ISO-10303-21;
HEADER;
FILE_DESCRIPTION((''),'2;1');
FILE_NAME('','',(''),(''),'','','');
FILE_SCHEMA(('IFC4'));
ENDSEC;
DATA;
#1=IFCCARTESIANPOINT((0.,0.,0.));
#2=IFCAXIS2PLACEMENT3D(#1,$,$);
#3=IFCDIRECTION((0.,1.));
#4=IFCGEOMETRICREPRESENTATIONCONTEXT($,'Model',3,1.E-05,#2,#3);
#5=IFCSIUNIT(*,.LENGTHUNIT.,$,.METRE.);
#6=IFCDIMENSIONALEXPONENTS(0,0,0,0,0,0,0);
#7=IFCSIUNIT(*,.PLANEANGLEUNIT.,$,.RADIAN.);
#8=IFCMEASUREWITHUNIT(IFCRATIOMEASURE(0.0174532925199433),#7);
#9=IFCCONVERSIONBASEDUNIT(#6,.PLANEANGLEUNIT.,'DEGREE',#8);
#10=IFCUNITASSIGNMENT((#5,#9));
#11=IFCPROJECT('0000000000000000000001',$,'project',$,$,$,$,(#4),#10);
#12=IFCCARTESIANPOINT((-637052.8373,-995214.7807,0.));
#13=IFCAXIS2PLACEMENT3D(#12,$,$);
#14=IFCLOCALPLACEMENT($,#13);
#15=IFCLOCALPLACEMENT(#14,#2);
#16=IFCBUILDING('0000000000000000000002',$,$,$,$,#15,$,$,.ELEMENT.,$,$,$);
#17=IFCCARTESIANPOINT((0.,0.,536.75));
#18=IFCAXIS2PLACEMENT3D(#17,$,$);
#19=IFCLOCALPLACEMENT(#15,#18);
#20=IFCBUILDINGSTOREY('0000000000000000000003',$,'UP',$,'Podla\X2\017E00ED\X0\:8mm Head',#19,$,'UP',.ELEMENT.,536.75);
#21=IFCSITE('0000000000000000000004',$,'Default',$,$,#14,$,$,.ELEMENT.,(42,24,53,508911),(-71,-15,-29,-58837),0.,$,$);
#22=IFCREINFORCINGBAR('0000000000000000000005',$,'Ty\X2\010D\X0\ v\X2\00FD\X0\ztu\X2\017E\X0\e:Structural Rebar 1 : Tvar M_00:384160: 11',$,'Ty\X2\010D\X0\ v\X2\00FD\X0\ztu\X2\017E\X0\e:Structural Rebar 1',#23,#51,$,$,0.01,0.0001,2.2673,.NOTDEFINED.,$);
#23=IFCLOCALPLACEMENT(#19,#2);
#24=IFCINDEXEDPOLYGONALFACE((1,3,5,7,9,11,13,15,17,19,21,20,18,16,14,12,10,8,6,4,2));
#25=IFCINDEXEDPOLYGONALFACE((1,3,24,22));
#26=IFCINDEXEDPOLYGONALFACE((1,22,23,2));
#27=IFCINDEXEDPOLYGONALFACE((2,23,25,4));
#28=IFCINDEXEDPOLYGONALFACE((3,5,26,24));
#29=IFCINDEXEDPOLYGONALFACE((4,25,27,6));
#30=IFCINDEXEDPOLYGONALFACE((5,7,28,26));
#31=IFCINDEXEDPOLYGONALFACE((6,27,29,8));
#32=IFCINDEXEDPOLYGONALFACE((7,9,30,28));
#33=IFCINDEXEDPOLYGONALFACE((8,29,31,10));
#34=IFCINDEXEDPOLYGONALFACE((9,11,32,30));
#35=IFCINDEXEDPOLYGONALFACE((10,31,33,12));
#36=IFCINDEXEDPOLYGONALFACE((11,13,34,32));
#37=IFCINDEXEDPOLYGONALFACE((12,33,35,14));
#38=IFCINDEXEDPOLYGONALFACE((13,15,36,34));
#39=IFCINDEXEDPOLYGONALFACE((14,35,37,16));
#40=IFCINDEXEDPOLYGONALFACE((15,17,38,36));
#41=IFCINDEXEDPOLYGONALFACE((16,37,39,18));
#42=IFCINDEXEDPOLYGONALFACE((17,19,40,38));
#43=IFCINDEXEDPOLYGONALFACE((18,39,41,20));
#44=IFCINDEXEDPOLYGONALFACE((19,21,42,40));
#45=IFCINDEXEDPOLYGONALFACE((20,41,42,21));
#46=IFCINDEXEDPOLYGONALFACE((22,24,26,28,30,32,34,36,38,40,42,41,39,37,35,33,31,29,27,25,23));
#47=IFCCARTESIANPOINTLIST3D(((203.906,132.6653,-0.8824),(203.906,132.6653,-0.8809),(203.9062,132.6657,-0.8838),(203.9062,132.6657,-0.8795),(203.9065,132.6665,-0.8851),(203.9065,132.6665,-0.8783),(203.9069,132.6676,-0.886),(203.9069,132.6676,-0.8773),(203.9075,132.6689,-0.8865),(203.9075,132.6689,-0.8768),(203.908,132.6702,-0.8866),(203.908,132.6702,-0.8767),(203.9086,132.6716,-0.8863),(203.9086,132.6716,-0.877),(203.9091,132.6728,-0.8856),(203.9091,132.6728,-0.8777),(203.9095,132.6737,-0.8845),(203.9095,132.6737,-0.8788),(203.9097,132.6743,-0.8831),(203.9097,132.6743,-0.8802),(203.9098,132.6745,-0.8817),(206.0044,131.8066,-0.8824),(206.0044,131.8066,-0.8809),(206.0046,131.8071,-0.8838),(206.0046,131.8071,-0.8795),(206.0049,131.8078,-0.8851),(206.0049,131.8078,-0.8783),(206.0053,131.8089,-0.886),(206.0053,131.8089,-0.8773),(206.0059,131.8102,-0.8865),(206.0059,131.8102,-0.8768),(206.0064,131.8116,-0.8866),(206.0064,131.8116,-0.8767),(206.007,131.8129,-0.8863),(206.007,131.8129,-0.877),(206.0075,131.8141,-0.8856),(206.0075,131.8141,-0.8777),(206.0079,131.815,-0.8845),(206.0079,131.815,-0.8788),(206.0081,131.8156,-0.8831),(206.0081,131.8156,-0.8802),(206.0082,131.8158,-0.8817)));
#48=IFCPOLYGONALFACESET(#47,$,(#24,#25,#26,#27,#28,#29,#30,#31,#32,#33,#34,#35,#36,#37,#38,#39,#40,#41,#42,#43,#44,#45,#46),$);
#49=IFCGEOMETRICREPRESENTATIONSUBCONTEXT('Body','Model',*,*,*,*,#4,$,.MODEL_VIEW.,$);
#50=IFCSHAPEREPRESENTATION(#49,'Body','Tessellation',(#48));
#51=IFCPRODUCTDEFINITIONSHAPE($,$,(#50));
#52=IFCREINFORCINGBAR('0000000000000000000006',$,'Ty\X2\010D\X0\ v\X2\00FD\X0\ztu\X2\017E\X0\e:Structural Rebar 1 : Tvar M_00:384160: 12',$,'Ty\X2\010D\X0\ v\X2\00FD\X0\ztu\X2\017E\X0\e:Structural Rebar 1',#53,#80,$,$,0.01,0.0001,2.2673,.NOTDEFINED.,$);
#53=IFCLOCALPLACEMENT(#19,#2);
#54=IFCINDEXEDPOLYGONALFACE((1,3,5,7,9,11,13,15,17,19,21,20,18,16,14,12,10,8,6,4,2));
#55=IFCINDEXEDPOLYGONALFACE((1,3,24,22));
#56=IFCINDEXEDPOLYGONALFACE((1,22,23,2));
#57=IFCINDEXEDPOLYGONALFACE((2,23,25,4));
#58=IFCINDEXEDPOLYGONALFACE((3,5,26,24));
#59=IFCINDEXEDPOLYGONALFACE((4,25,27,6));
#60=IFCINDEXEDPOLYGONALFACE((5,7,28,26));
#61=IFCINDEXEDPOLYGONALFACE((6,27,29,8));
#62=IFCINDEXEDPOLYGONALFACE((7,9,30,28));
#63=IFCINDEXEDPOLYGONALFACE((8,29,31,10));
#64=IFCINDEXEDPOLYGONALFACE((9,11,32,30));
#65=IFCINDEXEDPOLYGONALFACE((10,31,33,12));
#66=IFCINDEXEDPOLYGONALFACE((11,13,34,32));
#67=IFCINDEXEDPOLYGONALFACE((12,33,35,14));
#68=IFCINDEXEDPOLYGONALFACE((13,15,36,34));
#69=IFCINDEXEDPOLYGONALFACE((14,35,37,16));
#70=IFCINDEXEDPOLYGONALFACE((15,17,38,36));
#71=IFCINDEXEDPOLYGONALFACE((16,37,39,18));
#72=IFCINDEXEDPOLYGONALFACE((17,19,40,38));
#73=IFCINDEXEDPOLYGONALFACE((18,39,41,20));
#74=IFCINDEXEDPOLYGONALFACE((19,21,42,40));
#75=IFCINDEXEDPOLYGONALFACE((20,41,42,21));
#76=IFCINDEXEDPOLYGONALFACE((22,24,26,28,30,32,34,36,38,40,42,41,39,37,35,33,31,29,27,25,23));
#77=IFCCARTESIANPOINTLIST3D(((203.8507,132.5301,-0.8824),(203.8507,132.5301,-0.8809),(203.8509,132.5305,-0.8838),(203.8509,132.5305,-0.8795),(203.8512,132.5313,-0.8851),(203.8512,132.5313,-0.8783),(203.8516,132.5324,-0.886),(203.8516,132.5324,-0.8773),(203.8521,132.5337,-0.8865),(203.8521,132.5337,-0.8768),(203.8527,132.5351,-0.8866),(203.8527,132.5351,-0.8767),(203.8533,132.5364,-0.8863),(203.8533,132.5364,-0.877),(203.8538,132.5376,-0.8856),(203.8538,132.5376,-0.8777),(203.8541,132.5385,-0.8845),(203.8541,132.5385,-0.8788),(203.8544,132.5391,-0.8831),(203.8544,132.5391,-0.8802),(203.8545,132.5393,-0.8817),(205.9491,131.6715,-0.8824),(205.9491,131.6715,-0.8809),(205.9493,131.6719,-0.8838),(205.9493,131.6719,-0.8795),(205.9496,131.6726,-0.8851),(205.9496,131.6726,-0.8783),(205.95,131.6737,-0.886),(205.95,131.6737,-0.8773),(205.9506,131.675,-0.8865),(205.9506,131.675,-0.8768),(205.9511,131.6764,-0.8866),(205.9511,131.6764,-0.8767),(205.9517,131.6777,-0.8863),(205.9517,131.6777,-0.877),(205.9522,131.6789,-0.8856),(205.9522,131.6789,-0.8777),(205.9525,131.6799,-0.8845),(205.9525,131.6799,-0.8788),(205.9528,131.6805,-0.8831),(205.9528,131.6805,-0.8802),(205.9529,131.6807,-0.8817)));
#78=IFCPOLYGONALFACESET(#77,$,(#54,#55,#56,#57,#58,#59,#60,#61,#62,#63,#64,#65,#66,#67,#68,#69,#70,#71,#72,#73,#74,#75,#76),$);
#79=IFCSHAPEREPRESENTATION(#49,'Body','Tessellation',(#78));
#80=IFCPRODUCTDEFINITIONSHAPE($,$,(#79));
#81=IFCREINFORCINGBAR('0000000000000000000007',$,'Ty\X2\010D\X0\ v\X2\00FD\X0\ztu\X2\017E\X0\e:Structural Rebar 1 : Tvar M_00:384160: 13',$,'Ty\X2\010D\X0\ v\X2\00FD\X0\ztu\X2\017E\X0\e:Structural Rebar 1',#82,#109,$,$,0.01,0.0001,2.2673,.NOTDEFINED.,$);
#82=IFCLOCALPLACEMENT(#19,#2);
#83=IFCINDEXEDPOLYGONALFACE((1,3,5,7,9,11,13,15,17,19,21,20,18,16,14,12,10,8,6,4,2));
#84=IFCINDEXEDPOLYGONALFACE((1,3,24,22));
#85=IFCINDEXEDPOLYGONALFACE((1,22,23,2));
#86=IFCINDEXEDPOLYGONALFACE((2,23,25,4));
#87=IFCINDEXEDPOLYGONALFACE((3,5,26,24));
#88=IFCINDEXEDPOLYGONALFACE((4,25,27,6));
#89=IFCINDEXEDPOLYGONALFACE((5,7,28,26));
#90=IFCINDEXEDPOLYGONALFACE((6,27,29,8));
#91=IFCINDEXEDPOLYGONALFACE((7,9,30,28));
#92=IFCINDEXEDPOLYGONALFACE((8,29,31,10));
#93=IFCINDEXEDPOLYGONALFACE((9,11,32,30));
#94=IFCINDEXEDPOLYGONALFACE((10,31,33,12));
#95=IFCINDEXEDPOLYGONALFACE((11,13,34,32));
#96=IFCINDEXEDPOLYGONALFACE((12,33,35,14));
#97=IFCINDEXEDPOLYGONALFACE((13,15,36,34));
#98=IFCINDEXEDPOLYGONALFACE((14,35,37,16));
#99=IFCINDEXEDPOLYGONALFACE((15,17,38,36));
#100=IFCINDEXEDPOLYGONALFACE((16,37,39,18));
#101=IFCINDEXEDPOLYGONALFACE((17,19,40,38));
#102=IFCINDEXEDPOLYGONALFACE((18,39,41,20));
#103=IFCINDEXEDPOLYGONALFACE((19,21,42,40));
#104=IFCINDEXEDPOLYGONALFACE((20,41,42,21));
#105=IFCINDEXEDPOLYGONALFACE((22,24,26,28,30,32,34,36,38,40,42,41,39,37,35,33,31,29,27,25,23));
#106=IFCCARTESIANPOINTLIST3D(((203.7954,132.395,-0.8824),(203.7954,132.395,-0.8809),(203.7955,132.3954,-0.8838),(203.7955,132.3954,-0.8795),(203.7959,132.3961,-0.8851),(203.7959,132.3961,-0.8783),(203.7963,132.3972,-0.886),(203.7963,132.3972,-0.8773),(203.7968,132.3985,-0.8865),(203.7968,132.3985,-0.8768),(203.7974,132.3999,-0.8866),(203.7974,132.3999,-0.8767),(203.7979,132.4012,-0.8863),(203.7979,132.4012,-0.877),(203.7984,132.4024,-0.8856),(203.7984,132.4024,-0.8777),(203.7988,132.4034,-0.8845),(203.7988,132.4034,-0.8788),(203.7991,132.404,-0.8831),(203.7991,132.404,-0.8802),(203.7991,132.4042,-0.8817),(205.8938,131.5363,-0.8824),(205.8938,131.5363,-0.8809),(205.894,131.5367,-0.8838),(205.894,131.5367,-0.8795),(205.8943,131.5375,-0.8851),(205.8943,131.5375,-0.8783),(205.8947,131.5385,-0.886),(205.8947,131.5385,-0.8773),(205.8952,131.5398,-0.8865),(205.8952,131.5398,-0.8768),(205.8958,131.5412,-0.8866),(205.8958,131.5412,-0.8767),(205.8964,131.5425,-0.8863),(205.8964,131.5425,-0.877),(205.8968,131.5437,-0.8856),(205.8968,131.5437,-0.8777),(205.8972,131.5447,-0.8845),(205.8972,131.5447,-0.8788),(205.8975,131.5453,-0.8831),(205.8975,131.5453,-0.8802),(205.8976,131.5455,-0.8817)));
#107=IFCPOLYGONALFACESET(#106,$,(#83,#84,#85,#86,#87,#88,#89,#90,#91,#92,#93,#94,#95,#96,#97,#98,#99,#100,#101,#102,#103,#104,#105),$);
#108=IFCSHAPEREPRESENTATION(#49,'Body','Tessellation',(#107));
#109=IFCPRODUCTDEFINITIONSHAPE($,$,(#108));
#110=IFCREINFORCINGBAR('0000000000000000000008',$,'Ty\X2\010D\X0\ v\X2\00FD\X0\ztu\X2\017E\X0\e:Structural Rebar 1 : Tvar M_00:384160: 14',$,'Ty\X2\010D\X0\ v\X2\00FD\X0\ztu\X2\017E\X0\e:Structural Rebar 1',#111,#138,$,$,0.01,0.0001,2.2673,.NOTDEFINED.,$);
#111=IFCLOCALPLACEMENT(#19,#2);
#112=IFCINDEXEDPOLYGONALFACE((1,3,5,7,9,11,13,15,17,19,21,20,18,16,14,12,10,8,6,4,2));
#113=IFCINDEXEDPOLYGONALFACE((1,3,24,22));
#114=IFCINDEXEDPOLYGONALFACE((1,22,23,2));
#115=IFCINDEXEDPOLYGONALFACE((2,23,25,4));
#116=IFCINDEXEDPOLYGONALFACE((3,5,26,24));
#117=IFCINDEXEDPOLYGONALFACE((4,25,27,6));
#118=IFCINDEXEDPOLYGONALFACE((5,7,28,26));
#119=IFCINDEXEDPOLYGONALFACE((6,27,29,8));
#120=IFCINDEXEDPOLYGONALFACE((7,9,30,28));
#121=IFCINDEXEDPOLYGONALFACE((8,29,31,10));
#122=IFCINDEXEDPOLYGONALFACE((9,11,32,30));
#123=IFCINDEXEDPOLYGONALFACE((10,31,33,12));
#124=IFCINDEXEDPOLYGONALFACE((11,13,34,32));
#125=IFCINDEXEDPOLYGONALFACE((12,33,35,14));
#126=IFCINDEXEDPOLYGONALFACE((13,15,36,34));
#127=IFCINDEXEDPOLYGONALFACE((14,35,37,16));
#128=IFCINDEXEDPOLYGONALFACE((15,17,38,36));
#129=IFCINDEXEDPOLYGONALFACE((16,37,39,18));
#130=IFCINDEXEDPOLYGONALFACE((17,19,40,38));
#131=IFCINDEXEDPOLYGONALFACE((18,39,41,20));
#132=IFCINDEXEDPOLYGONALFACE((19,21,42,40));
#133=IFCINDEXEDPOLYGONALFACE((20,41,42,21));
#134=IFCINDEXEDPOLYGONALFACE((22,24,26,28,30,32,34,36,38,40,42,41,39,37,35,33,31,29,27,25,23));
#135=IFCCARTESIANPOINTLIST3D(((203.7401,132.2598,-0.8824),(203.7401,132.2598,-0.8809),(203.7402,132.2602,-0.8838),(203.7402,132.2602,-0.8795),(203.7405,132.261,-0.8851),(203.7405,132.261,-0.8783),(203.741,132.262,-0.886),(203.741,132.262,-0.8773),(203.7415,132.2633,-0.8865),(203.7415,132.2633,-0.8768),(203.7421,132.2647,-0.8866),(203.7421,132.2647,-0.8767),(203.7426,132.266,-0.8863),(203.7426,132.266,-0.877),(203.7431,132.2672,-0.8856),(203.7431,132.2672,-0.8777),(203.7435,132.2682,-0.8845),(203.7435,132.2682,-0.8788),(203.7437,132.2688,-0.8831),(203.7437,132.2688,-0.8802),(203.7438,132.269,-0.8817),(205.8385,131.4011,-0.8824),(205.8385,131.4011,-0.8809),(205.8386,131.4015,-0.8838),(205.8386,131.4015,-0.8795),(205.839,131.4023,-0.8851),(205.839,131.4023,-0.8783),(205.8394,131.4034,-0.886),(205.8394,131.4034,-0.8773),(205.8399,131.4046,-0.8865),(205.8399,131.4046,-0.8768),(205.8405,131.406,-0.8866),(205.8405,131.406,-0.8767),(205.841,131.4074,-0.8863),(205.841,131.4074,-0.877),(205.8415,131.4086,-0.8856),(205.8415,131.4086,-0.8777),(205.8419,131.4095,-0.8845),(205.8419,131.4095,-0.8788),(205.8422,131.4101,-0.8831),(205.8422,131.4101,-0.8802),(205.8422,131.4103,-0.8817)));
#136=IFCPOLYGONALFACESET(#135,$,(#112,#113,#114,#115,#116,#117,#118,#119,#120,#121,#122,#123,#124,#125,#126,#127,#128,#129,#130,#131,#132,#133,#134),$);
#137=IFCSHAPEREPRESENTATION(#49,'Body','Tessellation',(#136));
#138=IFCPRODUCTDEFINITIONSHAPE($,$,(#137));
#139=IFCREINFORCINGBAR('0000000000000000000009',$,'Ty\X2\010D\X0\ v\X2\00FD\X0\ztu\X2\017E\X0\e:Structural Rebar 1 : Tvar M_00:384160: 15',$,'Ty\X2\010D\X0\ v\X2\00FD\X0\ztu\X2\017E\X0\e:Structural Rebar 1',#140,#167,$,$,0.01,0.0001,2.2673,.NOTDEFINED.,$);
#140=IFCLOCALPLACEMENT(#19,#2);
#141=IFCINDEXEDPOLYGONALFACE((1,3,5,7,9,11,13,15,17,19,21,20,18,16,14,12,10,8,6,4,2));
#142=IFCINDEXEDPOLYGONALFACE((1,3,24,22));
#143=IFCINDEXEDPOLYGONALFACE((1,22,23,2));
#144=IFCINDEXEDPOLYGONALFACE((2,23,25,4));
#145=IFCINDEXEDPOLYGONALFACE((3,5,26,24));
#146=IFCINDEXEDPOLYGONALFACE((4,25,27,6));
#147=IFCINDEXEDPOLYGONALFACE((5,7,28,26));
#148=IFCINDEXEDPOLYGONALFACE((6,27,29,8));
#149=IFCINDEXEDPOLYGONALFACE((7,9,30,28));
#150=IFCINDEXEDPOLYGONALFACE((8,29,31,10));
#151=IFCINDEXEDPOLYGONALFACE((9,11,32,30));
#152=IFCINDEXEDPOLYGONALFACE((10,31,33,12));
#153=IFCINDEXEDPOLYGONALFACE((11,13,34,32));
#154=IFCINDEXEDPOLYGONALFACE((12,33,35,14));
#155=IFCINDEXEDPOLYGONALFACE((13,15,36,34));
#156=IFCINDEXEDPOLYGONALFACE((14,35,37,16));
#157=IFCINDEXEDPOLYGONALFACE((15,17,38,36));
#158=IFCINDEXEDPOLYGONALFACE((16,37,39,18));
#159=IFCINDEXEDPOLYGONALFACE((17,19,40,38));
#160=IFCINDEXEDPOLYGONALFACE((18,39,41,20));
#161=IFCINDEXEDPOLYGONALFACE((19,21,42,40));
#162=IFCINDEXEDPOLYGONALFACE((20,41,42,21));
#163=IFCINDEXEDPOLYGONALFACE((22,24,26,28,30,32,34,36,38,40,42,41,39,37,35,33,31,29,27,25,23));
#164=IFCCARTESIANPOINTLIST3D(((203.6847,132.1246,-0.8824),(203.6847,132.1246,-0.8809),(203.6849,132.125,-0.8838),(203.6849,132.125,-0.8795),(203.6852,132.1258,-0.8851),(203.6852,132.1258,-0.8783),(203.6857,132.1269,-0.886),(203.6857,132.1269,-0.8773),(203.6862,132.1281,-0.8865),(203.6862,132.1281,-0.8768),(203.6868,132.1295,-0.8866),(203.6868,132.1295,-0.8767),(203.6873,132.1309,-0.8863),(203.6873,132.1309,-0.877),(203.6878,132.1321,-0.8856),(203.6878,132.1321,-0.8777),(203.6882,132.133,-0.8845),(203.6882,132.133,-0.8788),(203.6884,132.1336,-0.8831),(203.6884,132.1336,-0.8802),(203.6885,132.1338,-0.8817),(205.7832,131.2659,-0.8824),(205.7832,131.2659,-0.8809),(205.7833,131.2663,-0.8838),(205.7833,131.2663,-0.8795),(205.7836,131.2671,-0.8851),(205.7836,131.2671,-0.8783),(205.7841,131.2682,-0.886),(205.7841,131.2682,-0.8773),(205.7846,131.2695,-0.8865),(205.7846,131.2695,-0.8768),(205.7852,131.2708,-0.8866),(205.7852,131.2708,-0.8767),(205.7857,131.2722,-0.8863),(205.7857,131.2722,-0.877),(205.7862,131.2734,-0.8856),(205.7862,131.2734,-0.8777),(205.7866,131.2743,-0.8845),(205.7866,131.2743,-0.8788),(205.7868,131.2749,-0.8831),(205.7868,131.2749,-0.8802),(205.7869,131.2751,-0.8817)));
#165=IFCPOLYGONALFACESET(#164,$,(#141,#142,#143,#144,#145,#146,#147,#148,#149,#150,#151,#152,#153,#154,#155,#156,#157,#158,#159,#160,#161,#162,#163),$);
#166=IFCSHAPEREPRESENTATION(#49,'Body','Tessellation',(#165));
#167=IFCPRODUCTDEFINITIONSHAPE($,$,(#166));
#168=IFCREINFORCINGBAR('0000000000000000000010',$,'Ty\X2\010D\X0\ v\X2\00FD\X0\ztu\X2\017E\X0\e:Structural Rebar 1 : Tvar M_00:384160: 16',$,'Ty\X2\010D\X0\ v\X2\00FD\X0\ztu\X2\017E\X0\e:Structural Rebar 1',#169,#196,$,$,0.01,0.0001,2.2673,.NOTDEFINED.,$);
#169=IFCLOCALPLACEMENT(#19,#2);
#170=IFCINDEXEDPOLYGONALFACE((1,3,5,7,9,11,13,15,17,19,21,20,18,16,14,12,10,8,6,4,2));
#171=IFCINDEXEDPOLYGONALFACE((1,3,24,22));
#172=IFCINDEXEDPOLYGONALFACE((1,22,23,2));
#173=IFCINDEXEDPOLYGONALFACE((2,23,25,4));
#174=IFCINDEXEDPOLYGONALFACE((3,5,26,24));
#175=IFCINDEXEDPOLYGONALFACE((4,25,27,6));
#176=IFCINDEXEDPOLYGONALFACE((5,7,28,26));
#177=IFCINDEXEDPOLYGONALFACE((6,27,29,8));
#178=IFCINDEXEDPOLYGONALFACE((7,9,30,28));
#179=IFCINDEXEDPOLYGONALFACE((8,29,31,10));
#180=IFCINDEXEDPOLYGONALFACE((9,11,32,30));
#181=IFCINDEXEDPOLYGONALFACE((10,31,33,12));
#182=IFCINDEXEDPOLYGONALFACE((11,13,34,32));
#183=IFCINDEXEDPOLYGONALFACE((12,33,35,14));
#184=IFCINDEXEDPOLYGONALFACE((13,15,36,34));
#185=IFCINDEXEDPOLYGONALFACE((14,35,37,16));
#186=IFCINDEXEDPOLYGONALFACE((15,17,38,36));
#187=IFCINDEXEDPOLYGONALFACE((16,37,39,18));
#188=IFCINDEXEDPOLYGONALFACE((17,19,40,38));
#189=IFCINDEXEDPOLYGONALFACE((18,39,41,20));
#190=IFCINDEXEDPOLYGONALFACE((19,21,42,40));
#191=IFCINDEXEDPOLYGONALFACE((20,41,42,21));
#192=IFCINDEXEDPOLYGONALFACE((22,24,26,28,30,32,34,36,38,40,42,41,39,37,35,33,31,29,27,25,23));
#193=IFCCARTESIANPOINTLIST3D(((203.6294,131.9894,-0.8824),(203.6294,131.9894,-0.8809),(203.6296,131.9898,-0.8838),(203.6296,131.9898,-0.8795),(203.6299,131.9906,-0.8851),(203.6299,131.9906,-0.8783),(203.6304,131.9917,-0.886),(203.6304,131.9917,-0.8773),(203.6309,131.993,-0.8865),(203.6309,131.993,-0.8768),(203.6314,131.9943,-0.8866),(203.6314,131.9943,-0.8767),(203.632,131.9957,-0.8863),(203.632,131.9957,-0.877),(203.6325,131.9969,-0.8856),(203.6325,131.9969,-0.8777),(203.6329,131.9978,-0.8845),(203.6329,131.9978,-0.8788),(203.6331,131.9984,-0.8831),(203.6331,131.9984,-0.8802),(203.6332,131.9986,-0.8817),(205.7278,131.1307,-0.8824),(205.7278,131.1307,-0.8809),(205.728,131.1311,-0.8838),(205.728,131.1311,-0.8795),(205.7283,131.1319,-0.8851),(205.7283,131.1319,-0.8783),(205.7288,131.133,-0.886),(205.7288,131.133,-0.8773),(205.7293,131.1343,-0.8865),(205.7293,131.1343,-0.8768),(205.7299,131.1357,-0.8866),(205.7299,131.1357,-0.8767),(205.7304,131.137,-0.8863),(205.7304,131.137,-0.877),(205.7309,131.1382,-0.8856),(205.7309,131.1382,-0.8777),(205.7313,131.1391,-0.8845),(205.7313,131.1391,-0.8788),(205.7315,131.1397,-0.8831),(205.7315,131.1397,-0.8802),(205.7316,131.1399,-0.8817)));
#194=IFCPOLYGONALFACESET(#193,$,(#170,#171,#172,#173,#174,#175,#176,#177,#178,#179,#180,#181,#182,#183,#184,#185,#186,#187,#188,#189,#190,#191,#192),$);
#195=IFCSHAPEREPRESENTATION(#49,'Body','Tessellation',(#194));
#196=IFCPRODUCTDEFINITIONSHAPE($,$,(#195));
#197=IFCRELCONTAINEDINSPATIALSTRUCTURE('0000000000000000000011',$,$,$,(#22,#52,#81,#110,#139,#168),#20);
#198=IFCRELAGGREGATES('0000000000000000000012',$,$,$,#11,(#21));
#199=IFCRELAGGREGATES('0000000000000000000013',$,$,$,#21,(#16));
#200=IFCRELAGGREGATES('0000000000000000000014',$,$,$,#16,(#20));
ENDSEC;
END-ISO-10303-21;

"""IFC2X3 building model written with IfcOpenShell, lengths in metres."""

from ifc_helpers import new_model, entity, si_unit, converted_unit, direction, frame, origin, place, context, subcontext, project, spatial, element, save


model = new_model("IFC2X3")

# Units and contexts
model_context = context("Model", 3, precision=1e-05, world=origin(), true_north=direction((0.0, 1.0)))
body_context = subcontext(model_context, "Body", "Model", "MODEL_VIEW")
ifc_project = project(units=[si_unit("LENGTHUNIT", "METRE"), converted_unit("PLANEANGLEUNIT", "DEGREE", entity("IfcRatioMeasure", 0.0174532925199433), si_unit("PLANEANGLEUNIT", "RADIAN"), dimensions=[0, 0, 0, 0, 0, 0, 0])], contexts=[model_context])

# Site, building, storey
site_placement = place(None, frame((-637052.8373, -995214.7807, 0.0)))
site = spatial("IfcSite", under=ifc_project, at=site_placement, Name="Default", CompositionType="ELEMENT", RefLatitude=(42, 24, 53, 508911), RefLongitude=(-71, -15, -29, -58837), RefElevation=0.0)
building_placement = place(site_placement, origin())
building = spatial("IfcBuilding", under=site, at=building_placement, CompositionType="ELEMENT")
storey_placement = place(building_placement, frame((0.0, 0.0, 536.75)))
storey = spatial("IfcBuildingStorey", under=building, at=storey_placement, Name="UP", ObjectType="Podlaží:8mm Head", LongName="UP", CompositionType="ELEMENT", Elevation=536.75)

# Reinforcing bars
reinforcing_bar_1_placement = place(storey_placement, origin())
element("IfcReinforcingBar", 1, at=reinforcing_bar_1_placement, inside=storey, Name="Tyč výztuže:Structural Rebar 1 : Tvar M_00:384160: 11", ObjectType="Tyč výztuže:Structural Rebar 1", BarLength=2.2673, BarRole="NOTDEFINED", CrossSectionArea=0.0001, NominalDiameter=0.01, context=body_context, shape_type="AdvancedSweptSolid", body=[
    entity("IfcSweptDiskSolid", entity("IfcCompositeCurve", [entity("IfcCompositeCurveSegment", "CONTINUOUS", True, entity("IfcPolyline", [entity("IfcCartesianPoint", [-206.0063, -131.8112, 0.8817]), entity("IfcCartesianPoint", [-203.9079, -132.6699, 0.8817])]))], False), 0.005, None, 0.0, 1.0),
])
reinforcing_bar_2_placement = place(storey_placement, origin())
element("IfcReinforcingBar", 2, at=reinforcing_bar_2_placement, inside=storey, Name="Tyč výztuže:Structural Rebar 1 : Tvar M_00:384160: 12", ObjectType="Tyč výztuže:Structural Rebar 1", BarLength=2.2673, BarRole="NOTDEFINED", CrossSectionArea=0.0001, NominalDiameter=0.01, context=body_context, shape_type="AdvancedSweptSolid", body=[
    entity("IfcSweptDiskSolid", entity("IfcCompositeCurve", [entity("IfcCompositeCurveSegment", "CONTINUOUS", True, entity("IfcPolyline", [entity("IfcCartesianPoint", [-205.951, -131.676, 0.8817]), entity("IfcCartesianPoint", [-203.8526, -132.5347, 0.8817])]))], False), 0.005, None, 0.0, 1.0),
])
reinforcing_bar_3_placement = place(storey_placement, origin())
element("IfcReinforcingBar", 3, at=reinforcing_bar_3_placement, inside=storey, Name="Tyč výztuže:Structural Rebar 1 : Tvar M_00:384160: 13", ObjectType="Tyč výztuže:Structural Rebar 1", BarLength=2.2673, BarRole="NOTDEFINED", CrossSectionArea=0.0001, NominalDiameter=0.01, context=body_context, shape_type="AdvancedSweptSolid", body=[
    entity("IfcSweptDiskSolid", entity("IfcCompositeCurve", [entity("IfcCompositeCurveSegment", "CONTINUOUS", True, entity("IfcPolyline", [entity("IfcCartesianPoint", [-205.8957, -131.5409, 0.8817]), entity("IfcCartesianPoint", [-203.7973, -132.3995, 0.8817])]))], False), 0.005, None, 0.0, 1.0),
])
reinforcing_bar_4_placement = place(storey_placement, origin())
element("IfcReinforcingBar", 4, at=reinforcing_bar_4_placement, inside=storey, Name="Tyč výztuže:Structural Rebar 1 : Tvar M_00:384160: 14", ObjectType="Tyč výztuže:Structural Rebar 1", BarLength=2.2673, BarRole="NOTDEFINED", CrossSectionArea=0.0001, NominalDiameter=0.01, context=body_context, shape_type="AdvancedSweptSolid", body=[
    entity("IfcSweptDiskSolid", entity("IfcCompositeCurve", [entity("IfcCompositeCurveSegment", "CONTINUOUS", True, entity("IfcPolyline", [entity("IfcCartesianPoint", [-205.8403, -131.4057, 0.8817]), entity("IfcCartesianPoint", [-203.7419, -132.2644, 0.8817])]))], False), 0.005, None, 0.0, 1.0),
])
reinforcing_bar_5_placement = place(storey_placement, origin())
element("IfcReinforcingBar", 5, at=reinforcing_bar_5_placement, inside=storey, Name="Tyč výztuže:Structural Rebar 1 : Tvar M_00:384160: 15", ObjectType="Tyč výztuže:Structural Rebar 1", BarLength=2.2673, BarRole="NOTDEFINED", CrossSectionArea=0.0001, NominalDiameter=0.01, context=body_context, shape_type="AdvancedSweptSolid", body=[
    entity("IfcSweptDiskSolid", entity("IfcCompositeCurve", [entity("IfcCompositeCurveSegment", "CONTINUOUS", True, entity("IfcPolyline", [entity("IfcCartesianPoint", [-205.785, -131.2705, 0.8817]), entity("IfcCartesianPoint", [-203.6866, -132.1292, 0.8817])]))], False), 0.005, None, 0.0, 1.0),
])
reinforcing_bar_6_placement = place(storey_placement, origin())
element("IfcReinforcingBar", 6, at=reinforcing_bar_6_placement, inside=storey, Name="Tyč výztuže:Structural Rebar 1 : Tvar M_00:384160: 16", ObjectType="Tyč výztuže:Structural Rebar 1", BarLength=2.2673, BarRole="NOTDEFINED", CrossSectionArea=0.0001, NominalDiameter=0.01, context=body_context, shape_type="AdvancedSweptSolid", body=[
    entity("IfcSweptDiskSolid", entity("IfcCompositeCurve", [entity("IfcCompositeCurveSegment", "CONTINUOUS", True, entity("IfcPolyline", [entity("IfcCartesianPoint", [-205.7297, -131.1353, 0.8817]), entity("IfcCartesianPoint", [-203.6313, -131.994, 0.8817])]))], False), 0.005, None, 0.0, 1.0),
])

save(model, "model.ifc")
